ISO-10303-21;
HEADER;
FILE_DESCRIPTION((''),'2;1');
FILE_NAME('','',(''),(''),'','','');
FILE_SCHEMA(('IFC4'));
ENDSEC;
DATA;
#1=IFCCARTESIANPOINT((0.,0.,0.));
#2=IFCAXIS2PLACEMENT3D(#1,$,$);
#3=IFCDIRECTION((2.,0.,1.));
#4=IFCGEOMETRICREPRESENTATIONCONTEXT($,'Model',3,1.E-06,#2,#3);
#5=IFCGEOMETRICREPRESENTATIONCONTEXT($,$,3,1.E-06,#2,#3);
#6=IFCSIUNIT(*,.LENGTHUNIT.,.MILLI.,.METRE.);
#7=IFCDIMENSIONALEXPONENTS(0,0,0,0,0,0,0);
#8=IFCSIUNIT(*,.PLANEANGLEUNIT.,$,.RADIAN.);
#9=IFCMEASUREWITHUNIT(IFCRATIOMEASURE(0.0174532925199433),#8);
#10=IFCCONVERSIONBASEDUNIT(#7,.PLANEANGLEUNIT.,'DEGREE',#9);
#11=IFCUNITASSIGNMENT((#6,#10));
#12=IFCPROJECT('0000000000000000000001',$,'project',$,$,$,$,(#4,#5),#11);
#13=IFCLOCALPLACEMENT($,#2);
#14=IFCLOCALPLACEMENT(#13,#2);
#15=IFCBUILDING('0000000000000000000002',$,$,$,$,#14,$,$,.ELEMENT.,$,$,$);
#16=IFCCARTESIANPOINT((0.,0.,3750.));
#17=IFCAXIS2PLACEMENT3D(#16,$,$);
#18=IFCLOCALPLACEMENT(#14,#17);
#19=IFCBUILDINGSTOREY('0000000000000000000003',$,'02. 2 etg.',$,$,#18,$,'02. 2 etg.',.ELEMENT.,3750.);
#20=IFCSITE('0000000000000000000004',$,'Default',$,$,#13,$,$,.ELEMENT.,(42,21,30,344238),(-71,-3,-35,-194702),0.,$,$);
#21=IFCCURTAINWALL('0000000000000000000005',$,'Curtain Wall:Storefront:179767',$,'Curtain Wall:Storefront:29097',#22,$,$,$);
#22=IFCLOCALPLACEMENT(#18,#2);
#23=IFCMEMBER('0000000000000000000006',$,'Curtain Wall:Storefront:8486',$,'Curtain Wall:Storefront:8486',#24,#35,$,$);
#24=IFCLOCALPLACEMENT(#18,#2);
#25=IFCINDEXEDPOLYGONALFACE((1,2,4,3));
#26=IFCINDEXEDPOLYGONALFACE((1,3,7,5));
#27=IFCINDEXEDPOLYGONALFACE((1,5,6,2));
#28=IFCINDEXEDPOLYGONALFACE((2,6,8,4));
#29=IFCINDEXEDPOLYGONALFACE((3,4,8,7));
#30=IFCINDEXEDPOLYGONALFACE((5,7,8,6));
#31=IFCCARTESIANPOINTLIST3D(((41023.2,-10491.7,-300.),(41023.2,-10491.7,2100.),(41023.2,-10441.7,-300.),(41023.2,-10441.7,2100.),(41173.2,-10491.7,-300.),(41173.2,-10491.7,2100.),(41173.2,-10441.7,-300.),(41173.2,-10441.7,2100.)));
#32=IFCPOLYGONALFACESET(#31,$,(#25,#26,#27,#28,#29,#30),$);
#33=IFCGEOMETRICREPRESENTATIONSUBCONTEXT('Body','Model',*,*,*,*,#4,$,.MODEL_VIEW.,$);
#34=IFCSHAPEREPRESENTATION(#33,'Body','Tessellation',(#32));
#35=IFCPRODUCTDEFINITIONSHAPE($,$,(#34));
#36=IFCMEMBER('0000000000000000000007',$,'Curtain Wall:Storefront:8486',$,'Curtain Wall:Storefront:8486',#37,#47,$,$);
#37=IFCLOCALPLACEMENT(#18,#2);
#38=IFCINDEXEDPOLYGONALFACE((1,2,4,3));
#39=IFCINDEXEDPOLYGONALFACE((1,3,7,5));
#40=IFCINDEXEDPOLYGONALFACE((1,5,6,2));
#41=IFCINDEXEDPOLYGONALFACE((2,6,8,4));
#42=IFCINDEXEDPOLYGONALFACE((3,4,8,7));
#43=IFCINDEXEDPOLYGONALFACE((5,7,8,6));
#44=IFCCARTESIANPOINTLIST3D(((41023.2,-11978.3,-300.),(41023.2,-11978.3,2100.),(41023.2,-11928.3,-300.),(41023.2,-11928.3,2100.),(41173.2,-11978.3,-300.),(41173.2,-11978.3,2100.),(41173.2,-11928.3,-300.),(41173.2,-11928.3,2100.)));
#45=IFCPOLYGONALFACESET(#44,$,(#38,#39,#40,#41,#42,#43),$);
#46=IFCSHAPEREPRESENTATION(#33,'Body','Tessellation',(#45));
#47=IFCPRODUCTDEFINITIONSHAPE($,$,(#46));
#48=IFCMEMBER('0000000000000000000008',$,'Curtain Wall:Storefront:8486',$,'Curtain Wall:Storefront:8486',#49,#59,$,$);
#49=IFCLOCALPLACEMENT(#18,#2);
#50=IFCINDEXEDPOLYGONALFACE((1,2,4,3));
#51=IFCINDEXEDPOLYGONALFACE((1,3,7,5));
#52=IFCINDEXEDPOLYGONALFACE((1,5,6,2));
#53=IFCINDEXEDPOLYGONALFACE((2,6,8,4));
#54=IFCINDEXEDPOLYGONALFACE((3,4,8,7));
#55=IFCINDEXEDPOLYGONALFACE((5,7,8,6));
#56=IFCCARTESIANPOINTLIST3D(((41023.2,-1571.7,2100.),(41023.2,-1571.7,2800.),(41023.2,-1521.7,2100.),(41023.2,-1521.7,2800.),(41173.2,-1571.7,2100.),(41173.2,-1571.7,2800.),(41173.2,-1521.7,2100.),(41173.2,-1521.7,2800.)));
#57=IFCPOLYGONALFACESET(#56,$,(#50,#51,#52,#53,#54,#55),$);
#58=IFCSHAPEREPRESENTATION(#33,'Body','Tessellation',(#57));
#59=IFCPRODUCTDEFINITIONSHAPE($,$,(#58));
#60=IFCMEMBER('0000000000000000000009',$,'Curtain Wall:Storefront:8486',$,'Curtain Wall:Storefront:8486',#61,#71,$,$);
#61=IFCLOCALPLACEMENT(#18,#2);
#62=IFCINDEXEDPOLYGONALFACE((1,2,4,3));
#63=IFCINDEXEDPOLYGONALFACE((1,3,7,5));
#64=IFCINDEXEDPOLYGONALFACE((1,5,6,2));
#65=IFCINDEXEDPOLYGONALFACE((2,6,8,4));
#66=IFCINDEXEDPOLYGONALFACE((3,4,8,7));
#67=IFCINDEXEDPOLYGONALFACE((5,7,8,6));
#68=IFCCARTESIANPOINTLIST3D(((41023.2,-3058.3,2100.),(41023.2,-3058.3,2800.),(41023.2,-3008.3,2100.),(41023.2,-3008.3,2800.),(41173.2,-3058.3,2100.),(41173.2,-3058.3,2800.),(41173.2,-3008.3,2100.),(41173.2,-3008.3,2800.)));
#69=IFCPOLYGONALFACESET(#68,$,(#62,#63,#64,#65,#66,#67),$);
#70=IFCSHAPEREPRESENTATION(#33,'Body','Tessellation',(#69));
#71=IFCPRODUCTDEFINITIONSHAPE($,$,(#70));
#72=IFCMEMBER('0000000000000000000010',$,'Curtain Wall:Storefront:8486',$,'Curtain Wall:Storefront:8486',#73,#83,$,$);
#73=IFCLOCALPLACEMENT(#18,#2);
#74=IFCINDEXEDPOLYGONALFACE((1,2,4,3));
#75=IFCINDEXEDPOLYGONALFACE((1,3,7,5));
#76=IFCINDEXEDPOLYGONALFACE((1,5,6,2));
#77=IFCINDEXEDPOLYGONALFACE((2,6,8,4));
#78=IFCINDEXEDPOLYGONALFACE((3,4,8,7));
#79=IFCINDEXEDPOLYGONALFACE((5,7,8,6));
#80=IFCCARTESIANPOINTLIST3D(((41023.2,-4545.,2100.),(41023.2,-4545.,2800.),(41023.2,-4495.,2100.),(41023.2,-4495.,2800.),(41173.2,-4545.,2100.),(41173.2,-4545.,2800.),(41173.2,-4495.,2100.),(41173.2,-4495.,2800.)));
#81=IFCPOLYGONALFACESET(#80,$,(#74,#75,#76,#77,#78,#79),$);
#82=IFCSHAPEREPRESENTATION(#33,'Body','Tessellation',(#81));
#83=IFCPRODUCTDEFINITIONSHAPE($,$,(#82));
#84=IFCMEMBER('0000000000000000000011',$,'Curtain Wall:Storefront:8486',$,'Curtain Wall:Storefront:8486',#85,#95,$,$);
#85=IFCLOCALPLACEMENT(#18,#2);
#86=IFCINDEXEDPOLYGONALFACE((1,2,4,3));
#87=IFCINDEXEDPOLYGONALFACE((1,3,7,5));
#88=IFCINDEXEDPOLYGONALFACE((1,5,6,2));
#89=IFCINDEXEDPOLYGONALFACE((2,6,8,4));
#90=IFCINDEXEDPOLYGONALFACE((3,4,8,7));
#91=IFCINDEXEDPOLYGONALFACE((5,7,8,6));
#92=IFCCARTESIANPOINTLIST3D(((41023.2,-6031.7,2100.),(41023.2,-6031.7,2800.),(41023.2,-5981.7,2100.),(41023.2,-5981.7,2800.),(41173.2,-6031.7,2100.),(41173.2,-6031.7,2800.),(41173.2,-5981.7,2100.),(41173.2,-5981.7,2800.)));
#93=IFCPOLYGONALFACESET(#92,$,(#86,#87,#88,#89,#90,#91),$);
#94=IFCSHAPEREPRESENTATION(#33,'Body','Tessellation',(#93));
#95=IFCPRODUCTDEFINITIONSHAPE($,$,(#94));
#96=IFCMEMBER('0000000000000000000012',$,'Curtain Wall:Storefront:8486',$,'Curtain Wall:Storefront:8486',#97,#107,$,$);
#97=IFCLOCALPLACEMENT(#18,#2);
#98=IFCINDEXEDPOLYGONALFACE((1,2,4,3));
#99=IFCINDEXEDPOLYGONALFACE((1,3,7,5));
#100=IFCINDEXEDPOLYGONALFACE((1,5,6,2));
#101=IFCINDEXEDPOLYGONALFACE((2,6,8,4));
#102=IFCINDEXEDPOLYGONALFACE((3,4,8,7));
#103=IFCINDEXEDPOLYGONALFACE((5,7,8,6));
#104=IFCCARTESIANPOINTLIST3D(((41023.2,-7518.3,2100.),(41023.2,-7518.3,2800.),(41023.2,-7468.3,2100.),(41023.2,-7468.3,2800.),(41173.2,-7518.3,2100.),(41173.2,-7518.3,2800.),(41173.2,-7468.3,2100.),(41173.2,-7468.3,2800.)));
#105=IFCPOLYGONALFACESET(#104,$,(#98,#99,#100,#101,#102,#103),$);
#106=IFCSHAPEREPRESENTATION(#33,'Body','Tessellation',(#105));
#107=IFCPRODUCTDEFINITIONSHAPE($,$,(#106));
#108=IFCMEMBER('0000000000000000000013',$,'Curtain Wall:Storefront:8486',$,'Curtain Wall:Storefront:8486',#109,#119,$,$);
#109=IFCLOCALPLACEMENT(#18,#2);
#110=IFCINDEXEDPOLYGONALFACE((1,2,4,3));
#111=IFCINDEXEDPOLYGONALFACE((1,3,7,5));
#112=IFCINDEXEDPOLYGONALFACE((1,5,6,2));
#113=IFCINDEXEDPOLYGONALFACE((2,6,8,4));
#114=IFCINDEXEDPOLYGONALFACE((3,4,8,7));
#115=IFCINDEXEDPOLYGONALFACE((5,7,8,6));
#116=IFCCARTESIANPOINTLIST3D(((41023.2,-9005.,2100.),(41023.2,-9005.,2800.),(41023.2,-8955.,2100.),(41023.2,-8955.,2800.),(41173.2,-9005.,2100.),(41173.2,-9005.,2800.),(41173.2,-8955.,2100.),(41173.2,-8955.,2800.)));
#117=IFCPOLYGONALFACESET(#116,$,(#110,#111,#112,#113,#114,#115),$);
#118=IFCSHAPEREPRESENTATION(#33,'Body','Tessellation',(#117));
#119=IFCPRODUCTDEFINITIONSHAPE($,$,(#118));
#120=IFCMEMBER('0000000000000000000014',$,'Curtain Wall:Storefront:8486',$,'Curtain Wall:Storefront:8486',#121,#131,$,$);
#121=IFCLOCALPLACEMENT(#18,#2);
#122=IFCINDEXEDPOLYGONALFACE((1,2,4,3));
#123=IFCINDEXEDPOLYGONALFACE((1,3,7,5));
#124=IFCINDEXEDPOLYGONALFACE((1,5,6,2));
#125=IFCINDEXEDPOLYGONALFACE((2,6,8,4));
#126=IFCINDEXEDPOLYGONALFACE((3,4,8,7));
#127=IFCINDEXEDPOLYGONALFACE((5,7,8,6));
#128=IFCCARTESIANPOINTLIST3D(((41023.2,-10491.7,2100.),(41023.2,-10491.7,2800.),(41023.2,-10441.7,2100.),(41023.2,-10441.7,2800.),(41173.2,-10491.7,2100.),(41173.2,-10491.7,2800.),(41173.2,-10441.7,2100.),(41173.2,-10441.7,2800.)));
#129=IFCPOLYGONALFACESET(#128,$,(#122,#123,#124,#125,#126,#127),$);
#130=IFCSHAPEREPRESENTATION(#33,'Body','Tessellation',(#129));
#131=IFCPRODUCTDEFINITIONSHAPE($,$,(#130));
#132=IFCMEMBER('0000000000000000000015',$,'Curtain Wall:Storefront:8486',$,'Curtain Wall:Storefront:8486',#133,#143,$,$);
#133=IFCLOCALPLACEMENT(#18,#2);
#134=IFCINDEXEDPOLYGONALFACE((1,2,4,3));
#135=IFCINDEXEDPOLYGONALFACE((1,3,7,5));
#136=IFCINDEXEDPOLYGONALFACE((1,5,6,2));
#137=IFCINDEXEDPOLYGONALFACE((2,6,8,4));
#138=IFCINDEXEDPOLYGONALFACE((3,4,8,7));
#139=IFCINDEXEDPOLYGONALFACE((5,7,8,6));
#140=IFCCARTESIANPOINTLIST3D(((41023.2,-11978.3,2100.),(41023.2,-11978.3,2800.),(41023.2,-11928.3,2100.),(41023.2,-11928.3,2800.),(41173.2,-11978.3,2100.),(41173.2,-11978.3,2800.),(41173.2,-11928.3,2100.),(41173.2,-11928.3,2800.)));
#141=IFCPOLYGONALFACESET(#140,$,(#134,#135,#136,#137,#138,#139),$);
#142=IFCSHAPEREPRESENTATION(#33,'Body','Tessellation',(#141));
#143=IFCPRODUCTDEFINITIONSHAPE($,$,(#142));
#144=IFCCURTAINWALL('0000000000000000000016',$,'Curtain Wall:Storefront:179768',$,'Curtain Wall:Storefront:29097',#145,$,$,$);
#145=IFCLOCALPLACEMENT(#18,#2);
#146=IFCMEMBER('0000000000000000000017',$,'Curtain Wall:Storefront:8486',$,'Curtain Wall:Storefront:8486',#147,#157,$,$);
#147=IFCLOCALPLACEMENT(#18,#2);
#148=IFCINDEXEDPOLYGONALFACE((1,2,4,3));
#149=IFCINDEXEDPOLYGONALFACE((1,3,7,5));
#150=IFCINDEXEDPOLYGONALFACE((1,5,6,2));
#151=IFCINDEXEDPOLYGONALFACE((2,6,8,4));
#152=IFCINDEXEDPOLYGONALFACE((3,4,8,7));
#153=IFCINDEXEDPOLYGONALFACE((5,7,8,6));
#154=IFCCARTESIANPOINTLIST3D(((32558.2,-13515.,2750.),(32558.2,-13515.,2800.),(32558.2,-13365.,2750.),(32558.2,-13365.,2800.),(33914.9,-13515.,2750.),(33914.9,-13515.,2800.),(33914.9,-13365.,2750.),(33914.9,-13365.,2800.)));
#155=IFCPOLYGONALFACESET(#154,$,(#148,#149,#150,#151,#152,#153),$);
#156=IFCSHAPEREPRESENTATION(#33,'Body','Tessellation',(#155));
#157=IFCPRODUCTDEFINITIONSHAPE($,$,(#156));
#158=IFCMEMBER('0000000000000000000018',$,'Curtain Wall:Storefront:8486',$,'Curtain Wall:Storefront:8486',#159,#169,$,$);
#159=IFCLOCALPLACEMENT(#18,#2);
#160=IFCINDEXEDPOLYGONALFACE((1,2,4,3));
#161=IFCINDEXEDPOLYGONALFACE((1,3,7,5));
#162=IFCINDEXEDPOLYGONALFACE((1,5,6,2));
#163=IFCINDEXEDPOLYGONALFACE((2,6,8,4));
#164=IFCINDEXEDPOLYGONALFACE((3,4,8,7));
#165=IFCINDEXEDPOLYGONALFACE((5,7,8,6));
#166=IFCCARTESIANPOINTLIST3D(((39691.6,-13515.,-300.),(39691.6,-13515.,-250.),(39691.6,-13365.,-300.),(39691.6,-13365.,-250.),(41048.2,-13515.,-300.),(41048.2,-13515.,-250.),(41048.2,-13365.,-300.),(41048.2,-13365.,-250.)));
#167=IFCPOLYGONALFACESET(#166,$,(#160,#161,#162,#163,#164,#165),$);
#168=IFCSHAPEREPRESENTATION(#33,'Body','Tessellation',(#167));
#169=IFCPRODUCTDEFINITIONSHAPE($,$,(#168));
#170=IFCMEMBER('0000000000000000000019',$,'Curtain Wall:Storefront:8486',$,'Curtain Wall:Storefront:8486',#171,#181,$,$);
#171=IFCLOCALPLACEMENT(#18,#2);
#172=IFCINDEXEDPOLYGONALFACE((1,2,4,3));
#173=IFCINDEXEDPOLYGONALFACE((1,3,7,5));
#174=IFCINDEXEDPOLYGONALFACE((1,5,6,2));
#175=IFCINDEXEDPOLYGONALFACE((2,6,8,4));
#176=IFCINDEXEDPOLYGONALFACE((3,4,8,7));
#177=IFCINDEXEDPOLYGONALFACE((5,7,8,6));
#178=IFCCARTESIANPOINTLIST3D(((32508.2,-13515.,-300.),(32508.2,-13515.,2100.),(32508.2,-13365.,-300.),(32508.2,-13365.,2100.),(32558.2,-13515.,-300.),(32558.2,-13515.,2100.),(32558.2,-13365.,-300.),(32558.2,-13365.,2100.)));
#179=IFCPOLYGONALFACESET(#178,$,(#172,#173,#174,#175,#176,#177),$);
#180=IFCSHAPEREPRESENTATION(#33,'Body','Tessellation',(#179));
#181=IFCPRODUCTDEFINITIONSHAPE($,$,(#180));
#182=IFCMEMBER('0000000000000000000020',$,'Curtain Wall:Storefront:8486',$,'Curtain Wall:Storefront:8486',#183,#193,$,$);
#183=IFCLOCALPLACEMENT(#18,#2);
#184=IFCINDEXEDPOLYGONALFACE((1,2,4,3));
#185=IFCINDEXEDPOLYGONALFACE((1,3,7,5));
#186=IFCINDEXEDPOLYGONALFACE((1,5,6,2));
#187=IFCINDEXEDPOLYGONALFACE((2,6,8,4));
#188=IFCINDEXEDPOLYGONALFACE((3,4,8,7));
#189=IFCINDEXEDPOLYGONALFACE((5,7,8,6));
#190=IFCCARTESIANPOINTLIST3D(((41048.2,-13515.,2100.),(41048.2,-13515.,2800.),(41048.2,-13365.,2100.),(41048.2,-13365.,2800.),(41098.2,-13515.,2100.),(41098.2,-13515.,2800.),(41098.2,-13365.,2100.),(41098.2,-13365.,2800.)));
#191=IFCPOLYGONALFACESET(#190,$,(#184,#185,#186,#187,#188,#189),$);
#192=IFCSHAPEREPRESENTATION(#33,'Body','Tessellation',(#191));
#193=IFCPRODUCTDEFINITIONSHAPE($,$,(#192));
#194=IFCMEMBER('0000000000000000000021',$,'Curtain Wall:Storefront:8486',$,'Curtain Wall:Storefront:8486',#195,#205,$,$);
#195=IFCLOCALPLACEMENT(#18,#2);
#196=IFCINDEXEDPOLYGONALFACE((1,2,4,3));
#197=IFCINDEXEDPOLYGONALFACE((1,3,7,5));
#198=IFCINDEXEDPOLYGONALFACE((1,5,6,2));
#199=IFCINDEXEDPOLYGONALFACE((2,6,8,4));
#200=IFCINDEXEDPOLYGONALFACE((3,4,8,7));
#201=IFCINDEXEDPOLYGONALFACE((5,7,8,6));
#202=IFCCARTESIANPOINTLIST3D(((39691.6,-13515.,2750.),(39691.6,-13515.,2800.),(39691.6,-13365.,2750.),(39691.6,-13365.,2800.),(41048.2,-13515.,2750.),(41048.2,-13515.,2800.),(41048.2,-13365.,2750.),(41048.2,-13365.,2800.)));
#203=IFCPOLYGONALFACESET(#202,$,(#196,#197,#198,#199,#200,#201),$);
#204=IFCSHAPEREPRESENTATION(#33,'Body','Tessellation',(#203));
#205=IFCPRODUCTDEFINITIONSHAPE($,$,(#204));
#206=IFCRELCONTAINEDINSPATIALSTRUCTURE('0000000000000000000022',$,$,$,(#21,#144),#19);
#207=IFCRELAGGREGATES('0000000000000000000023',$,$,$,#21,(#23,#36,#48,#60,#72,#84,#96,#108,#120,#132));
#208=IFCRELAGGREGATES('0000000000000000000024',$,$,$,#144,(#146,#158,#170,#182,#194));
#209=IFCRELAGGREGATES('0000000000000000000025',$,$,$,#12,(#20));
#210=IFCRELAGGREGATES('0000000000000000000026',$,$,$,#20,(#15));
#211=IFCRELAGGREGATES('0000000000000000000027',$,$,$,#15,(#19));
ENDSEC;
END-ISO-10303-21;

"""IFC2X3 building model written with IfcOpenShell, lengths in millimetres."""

from ifc_helpers import new_model, entity, si_unit, converted_unit, direction, frame, frame_2d, origin, origin_2d_with_axis, place, context, subcontext, project, spatial, rectangle, extrude, element, aggregate, save


model = new_model("IFC2X3")

# Units and contexts
model_context = context("Model", 3, precision=1e-06, world=origin(), true_north=direction((2.0, 0.0, 1.0)))
context_of_model = context(None, 3, precision=1e-06, world=origin(), true_north=direction((2.0, 0.0, 1.0)))
body_context = subcontext(model_context, "Body", "Model", "MODEL_VIEW")
ifc_project = project(units=[si_unit("LENGTHUNIT", "METRE", prefix="MILLI"), converted_unit("PLANEANGLEUNIT", "DEGREE", entity("IfcRatioMeasure", 0.0174532925199433), si_unit("PLANEANGLEUNIT", "RADIAN"), dimensions=[0, 0, 0, 0, 0, 0, 0])], contexts=[model_context, context_of_model])

# Site, building, storey
site_placement = place(None, origin())
site = spatial("IfcSite", under=ifc_project, at=site_placement, Name="Default", CompositionType="ELEMENT", RefLatitude=(42, 21, 30, 344238), RefLongitude=(-71, -3, -35, -194702), RefElevation=0.0)
building_placement = place(site_placement, origin())
building = spatial("IfcBuilding", under=site, at=building_placement, CompositionType="ELEMENT")
storey_placement = place(building_placement, frame((0.0, 0.0, 3750.0)))
storey = spatial("IfcBuildingStorey", under=building, at=storey_placement, Name="02. 2 etg.", LongName="02. 2 etg.", CompositionType="ELEMENT", Elevation=3750.0)

# Curtain walls, members
curtain_wall_1_placement = place(storey_placement, origin())
curtain_wall_1 = element("IfcCurtainWall", 1, at=curtain_wall_1_placement, inside=storey, Name="Curtain Wall:Storefront:179767", ObjectType="Curtain Wall:Storefront:29097")
member_1_placement = place(storey_placement, origin())
member_1 = element("IfcMember", 2, at=member_1_placement, Name="Curtain Wall:Storefront:8486", ObjectType="Curtain Wall:Storefront:8486", context=body_context, shape_type="SweptSolid", body=[
    extrude(rectangle(XDim=150.0, YDim=50.0, at=frame_2d((0.0, 0.0), x_axis=(1.0, 0.0))), frame((41098.2, -10466.7, -300.0)), (0.0, 0.0, 1.0), 2400.0),
])
member_2_placement = place(storey_placement, origin())
member_2 = element("IfcMember", 3, at=member_2_placement, Name="Curtain Wall:Storefront:8486", ObjectType="Curtain Wall:Storefront:8486", context=body_context, shape_type="SweptSolid", body=[
    extrude(rectangle(XDim=150.0, YDim=50.0, at=frame_2d((0.0, 0.0), x_axis=(1.0, 0.0))), frame((41098.2, -11953.3, -300.0)), (0.0, 0.0, 1.0), 2400.0),
])
member_3_placement = place(storey_placement, origin())
member_3 = element("IfcMember", 4, at=member_3_placement, Name="Curtain Wall:Storefront:8486", ObjectType="Curtain Wall:Storefront:8486", context=body_context, shape_type="SweptSolid", body=[
    extrude(rectangle(XDim=150.0, YDim=50.0, at=origin_2d_with_axis()), frame((41098.2, -1546.7, 2100.0)), (0.0, 0.0, 1.0), 700.0),
])
member_4_placement = place(storey_placement, origin())
member_4 = element("IfcMember", 5, at=member_4_placement, Name="Curtain Wall:Storefront:8486", ObjectType="Curtain Wall:Storefront:8486", context=body_context, shape_type="SweptSolid", body=[
    extrude(rectangle(XDim=150.0, YDim=50.0, at=origin_2d_with_axis()), frame((41098.2, -3033.3, 2100.0)), (0.0, 0.0, 1.0), 700.0),
])
member_5_placement = place(storey_placement, origin())
member_5 = element("IfcMember", 6, at=member_5_placement, Name="Curtain Wall:Storefront:8486", ObjectType="Curtain Wall:Storefront:8486", context=body_context, shape_type="SweptSolid", body=[
    extrude(rectangle(XDim=150.0, YDim=50.0, at=origin_2d_with_axis()), frame((41098.2, -4520.0, 2100.0)), (0.0, 0.0, 1.0), 700.0),
])
member_6_placement = place(storey_placement, origin())
member_6 = element("IfcMember", 7, at=member_6_placement, Name="Curtain Wall:Storefront:8486", ObjectType="Curtain Wall:Storefront:8486", context=body_context, shape_type="SweptSolid", body=[
    extrude(rectangle(XDim=150.0, YDim=50.0, at=origin_2d_with_axis()), frame((41098.2, -6006.7, 2100.0)), (0.0, 0.0, 1.0), 700.0),
])
member_7_placement = place(storey_placement, origin())
member_7 = element("IfcMember", 8, at=member_7_placement, Name="Curtain Wall:Storefront:8486", ObjectType="Curtain Wall:Storefront:8486", context=body_context, shape_type="SweptSolid", body=[
    extrude(rectangle(XDim=150.0, YDim=50.0, at=origin_2d_with_axis()), frame((41098.2, -7493.3, 2100.0)), (0.0, 0.0, 1.0), 700.0),
])
member_8_placement = place(storey_placement, origin())
member_8 = element("IfcMember", 9, at=member_8_placement, Name="Curtain Wall:Storefront:8486", ObjectType="Curtain Wall:Storefront:8486", context=body_context, shape_type="SweptSolid", body=[
    extrude(rectangle(XDim=150.0, YDim=50.0, at=origin_2d_with_axis()), frame((41098.2, -8980.0, 2100.0)), (0.0, 0.0, 1.0), 700.0),
])
member_9_placement = place(storey_placement, origin())
member_9 = element("IfcMember", 10, at=member_9_placement, Name="Curtain Wall:Storefront:8486", ObjectType="Curtain Wall:Storefront:8486", context=body_context, shape_type="SweptSolid", body=[
    extrude(rectangle(XDim=150.0, YDim=50.0, at=origin_2d_with_axis()), frame((41098.2, -10466.7, 2100.0)), (0.0, 0.0, 1.0), 700.0),
])
member_10_placement = place(storey_placement, origin())
member_10 = element("IfcMember", 11, at=member_10_placement, Name="Curtain Wall:Storefront:8486", ObjectType="Curtain Wall:Storefront:8486", context=body_context, shape_type="SweptSolid", body=[
    extrude(rectangle(XDim=150.0, YDim=50.0, at=origin_2d_with_axis()), frame((41098.2, -11953.3, 2100.0)), (0.0, 0.0, 1.0), 700.0),
])
aggregate(curtain_wall_1, [member_1, member_2, member_3, member_4, member_5, member_6, member_7, member_8, member_9, member_10])
curtain_wall_2_placement = place(storey_placement, origin())
curtain_wall_2 = element("IfcCurtainWall", 12, at=curtain_wall_2_placement, inside=storey, Name="Curtain Wall:Storefront:179768", ObjectType="Curtain Wall:Storefront:29097")
member_11_placement = place(storey_placement, origin())
member_11 = element("IfcMember", 13, at=member_11_placement, Name="Curtain Wall:Storefront:8486", ObjectType="Curtain Wall:Storefront:8486", context=body_context, shape_type="SweptSolid", body=[
    extrude(rectangle(XDim=1356.7, YDim=150.0, at=origin_2d_with_axis()), frame((33236.6, -13440.0, 2750.0)), (0.0, 0.0, 1.0), 50.0),
])
member_12_placement = place(storey_placement, origin())
member_12 = element("IfcMember", 14, at=member_12_placement, Name="Curtain Wall:Storefront:8486", ObjectType="Curtain Wall:Storefront:8486", context=body_context, shape_type="SweptSolid", body=[
    extrude(rectangle(XDim=1356.7, YDim=150.0, at=frame_2d((0.0, 0.0), x_axis=(1.0, 0.0))), frame((40369.9, -13440.0, -300.0), z_axis=(0.0, 0.0, 1.0), x_axis=(-1.0, 0.0, 0.0)), (0.0, 0.0, 1.0), 50.0),
])
member_13_placement = place(storey_placement, origin())
member_13 = element("IfcMember", 15, at=member_13_placement, Name="Curtain Wall:Storefront:8486", ObjectType="Curtain Wall:Storefront:8486", context=body_context, shape_type="SweptSolid", body=[
    extrude(rectangle(XDim=150.0, YDim=50.0, at=frame_2d((0.0, 0.0), x_axis=(1.0, 0.0))), frame((32533.2, -13440.0, -300.0), z_axis=(0.0, 0.0, 1.0), x_axis=(0.0, -1.0, 0.0)), (0.0, 0.0, 1.0), 2400.0),
])
member_14_placement = place(storey_placement, origin())
member_14 = element("IfcMember", 16, at=member_14_placement, Name="Curtain Wall:Storefront:8486", ObjectType="Curtain Wall:Storefront:8486", context=body_context, shape_type="SweptSolid", body=[
    extrude(rectangle(XDim=50.0, YDim=150.0, at=frame_2d((0.0, 0.0), x_axis=(1.0, 0.0))), frame((41073.2, -13440.0, 2100.0), z_axis=(0.0, 0.0, 1.0), x_axis=(-1.0, 0.0, 0.0)), (0.0, 0.0, 1.0), 700.0),
])
member_15_placement = place(storey_placement, origin())
member_15 = element("IfcMember", 17, at=member_15_placement, Name="Curtain Wall:Storefront:8486", ObjectType="Curtain Wall:Storefront:8486", context=body_context, shape_type="SweptSolid", body=[
    extrude(rectangle(XDim=1356.7, YDim=150.0, at=origin_2d_with_axis()), frame((40369.9, -13440.0, 2750.0)), (0.0, 0.0, 1.0), 50.0),
])
aggregate(curtain_wall_2, [member_11, member_12, member_13, member_14, member_15])

save(model, "model.ifc")
